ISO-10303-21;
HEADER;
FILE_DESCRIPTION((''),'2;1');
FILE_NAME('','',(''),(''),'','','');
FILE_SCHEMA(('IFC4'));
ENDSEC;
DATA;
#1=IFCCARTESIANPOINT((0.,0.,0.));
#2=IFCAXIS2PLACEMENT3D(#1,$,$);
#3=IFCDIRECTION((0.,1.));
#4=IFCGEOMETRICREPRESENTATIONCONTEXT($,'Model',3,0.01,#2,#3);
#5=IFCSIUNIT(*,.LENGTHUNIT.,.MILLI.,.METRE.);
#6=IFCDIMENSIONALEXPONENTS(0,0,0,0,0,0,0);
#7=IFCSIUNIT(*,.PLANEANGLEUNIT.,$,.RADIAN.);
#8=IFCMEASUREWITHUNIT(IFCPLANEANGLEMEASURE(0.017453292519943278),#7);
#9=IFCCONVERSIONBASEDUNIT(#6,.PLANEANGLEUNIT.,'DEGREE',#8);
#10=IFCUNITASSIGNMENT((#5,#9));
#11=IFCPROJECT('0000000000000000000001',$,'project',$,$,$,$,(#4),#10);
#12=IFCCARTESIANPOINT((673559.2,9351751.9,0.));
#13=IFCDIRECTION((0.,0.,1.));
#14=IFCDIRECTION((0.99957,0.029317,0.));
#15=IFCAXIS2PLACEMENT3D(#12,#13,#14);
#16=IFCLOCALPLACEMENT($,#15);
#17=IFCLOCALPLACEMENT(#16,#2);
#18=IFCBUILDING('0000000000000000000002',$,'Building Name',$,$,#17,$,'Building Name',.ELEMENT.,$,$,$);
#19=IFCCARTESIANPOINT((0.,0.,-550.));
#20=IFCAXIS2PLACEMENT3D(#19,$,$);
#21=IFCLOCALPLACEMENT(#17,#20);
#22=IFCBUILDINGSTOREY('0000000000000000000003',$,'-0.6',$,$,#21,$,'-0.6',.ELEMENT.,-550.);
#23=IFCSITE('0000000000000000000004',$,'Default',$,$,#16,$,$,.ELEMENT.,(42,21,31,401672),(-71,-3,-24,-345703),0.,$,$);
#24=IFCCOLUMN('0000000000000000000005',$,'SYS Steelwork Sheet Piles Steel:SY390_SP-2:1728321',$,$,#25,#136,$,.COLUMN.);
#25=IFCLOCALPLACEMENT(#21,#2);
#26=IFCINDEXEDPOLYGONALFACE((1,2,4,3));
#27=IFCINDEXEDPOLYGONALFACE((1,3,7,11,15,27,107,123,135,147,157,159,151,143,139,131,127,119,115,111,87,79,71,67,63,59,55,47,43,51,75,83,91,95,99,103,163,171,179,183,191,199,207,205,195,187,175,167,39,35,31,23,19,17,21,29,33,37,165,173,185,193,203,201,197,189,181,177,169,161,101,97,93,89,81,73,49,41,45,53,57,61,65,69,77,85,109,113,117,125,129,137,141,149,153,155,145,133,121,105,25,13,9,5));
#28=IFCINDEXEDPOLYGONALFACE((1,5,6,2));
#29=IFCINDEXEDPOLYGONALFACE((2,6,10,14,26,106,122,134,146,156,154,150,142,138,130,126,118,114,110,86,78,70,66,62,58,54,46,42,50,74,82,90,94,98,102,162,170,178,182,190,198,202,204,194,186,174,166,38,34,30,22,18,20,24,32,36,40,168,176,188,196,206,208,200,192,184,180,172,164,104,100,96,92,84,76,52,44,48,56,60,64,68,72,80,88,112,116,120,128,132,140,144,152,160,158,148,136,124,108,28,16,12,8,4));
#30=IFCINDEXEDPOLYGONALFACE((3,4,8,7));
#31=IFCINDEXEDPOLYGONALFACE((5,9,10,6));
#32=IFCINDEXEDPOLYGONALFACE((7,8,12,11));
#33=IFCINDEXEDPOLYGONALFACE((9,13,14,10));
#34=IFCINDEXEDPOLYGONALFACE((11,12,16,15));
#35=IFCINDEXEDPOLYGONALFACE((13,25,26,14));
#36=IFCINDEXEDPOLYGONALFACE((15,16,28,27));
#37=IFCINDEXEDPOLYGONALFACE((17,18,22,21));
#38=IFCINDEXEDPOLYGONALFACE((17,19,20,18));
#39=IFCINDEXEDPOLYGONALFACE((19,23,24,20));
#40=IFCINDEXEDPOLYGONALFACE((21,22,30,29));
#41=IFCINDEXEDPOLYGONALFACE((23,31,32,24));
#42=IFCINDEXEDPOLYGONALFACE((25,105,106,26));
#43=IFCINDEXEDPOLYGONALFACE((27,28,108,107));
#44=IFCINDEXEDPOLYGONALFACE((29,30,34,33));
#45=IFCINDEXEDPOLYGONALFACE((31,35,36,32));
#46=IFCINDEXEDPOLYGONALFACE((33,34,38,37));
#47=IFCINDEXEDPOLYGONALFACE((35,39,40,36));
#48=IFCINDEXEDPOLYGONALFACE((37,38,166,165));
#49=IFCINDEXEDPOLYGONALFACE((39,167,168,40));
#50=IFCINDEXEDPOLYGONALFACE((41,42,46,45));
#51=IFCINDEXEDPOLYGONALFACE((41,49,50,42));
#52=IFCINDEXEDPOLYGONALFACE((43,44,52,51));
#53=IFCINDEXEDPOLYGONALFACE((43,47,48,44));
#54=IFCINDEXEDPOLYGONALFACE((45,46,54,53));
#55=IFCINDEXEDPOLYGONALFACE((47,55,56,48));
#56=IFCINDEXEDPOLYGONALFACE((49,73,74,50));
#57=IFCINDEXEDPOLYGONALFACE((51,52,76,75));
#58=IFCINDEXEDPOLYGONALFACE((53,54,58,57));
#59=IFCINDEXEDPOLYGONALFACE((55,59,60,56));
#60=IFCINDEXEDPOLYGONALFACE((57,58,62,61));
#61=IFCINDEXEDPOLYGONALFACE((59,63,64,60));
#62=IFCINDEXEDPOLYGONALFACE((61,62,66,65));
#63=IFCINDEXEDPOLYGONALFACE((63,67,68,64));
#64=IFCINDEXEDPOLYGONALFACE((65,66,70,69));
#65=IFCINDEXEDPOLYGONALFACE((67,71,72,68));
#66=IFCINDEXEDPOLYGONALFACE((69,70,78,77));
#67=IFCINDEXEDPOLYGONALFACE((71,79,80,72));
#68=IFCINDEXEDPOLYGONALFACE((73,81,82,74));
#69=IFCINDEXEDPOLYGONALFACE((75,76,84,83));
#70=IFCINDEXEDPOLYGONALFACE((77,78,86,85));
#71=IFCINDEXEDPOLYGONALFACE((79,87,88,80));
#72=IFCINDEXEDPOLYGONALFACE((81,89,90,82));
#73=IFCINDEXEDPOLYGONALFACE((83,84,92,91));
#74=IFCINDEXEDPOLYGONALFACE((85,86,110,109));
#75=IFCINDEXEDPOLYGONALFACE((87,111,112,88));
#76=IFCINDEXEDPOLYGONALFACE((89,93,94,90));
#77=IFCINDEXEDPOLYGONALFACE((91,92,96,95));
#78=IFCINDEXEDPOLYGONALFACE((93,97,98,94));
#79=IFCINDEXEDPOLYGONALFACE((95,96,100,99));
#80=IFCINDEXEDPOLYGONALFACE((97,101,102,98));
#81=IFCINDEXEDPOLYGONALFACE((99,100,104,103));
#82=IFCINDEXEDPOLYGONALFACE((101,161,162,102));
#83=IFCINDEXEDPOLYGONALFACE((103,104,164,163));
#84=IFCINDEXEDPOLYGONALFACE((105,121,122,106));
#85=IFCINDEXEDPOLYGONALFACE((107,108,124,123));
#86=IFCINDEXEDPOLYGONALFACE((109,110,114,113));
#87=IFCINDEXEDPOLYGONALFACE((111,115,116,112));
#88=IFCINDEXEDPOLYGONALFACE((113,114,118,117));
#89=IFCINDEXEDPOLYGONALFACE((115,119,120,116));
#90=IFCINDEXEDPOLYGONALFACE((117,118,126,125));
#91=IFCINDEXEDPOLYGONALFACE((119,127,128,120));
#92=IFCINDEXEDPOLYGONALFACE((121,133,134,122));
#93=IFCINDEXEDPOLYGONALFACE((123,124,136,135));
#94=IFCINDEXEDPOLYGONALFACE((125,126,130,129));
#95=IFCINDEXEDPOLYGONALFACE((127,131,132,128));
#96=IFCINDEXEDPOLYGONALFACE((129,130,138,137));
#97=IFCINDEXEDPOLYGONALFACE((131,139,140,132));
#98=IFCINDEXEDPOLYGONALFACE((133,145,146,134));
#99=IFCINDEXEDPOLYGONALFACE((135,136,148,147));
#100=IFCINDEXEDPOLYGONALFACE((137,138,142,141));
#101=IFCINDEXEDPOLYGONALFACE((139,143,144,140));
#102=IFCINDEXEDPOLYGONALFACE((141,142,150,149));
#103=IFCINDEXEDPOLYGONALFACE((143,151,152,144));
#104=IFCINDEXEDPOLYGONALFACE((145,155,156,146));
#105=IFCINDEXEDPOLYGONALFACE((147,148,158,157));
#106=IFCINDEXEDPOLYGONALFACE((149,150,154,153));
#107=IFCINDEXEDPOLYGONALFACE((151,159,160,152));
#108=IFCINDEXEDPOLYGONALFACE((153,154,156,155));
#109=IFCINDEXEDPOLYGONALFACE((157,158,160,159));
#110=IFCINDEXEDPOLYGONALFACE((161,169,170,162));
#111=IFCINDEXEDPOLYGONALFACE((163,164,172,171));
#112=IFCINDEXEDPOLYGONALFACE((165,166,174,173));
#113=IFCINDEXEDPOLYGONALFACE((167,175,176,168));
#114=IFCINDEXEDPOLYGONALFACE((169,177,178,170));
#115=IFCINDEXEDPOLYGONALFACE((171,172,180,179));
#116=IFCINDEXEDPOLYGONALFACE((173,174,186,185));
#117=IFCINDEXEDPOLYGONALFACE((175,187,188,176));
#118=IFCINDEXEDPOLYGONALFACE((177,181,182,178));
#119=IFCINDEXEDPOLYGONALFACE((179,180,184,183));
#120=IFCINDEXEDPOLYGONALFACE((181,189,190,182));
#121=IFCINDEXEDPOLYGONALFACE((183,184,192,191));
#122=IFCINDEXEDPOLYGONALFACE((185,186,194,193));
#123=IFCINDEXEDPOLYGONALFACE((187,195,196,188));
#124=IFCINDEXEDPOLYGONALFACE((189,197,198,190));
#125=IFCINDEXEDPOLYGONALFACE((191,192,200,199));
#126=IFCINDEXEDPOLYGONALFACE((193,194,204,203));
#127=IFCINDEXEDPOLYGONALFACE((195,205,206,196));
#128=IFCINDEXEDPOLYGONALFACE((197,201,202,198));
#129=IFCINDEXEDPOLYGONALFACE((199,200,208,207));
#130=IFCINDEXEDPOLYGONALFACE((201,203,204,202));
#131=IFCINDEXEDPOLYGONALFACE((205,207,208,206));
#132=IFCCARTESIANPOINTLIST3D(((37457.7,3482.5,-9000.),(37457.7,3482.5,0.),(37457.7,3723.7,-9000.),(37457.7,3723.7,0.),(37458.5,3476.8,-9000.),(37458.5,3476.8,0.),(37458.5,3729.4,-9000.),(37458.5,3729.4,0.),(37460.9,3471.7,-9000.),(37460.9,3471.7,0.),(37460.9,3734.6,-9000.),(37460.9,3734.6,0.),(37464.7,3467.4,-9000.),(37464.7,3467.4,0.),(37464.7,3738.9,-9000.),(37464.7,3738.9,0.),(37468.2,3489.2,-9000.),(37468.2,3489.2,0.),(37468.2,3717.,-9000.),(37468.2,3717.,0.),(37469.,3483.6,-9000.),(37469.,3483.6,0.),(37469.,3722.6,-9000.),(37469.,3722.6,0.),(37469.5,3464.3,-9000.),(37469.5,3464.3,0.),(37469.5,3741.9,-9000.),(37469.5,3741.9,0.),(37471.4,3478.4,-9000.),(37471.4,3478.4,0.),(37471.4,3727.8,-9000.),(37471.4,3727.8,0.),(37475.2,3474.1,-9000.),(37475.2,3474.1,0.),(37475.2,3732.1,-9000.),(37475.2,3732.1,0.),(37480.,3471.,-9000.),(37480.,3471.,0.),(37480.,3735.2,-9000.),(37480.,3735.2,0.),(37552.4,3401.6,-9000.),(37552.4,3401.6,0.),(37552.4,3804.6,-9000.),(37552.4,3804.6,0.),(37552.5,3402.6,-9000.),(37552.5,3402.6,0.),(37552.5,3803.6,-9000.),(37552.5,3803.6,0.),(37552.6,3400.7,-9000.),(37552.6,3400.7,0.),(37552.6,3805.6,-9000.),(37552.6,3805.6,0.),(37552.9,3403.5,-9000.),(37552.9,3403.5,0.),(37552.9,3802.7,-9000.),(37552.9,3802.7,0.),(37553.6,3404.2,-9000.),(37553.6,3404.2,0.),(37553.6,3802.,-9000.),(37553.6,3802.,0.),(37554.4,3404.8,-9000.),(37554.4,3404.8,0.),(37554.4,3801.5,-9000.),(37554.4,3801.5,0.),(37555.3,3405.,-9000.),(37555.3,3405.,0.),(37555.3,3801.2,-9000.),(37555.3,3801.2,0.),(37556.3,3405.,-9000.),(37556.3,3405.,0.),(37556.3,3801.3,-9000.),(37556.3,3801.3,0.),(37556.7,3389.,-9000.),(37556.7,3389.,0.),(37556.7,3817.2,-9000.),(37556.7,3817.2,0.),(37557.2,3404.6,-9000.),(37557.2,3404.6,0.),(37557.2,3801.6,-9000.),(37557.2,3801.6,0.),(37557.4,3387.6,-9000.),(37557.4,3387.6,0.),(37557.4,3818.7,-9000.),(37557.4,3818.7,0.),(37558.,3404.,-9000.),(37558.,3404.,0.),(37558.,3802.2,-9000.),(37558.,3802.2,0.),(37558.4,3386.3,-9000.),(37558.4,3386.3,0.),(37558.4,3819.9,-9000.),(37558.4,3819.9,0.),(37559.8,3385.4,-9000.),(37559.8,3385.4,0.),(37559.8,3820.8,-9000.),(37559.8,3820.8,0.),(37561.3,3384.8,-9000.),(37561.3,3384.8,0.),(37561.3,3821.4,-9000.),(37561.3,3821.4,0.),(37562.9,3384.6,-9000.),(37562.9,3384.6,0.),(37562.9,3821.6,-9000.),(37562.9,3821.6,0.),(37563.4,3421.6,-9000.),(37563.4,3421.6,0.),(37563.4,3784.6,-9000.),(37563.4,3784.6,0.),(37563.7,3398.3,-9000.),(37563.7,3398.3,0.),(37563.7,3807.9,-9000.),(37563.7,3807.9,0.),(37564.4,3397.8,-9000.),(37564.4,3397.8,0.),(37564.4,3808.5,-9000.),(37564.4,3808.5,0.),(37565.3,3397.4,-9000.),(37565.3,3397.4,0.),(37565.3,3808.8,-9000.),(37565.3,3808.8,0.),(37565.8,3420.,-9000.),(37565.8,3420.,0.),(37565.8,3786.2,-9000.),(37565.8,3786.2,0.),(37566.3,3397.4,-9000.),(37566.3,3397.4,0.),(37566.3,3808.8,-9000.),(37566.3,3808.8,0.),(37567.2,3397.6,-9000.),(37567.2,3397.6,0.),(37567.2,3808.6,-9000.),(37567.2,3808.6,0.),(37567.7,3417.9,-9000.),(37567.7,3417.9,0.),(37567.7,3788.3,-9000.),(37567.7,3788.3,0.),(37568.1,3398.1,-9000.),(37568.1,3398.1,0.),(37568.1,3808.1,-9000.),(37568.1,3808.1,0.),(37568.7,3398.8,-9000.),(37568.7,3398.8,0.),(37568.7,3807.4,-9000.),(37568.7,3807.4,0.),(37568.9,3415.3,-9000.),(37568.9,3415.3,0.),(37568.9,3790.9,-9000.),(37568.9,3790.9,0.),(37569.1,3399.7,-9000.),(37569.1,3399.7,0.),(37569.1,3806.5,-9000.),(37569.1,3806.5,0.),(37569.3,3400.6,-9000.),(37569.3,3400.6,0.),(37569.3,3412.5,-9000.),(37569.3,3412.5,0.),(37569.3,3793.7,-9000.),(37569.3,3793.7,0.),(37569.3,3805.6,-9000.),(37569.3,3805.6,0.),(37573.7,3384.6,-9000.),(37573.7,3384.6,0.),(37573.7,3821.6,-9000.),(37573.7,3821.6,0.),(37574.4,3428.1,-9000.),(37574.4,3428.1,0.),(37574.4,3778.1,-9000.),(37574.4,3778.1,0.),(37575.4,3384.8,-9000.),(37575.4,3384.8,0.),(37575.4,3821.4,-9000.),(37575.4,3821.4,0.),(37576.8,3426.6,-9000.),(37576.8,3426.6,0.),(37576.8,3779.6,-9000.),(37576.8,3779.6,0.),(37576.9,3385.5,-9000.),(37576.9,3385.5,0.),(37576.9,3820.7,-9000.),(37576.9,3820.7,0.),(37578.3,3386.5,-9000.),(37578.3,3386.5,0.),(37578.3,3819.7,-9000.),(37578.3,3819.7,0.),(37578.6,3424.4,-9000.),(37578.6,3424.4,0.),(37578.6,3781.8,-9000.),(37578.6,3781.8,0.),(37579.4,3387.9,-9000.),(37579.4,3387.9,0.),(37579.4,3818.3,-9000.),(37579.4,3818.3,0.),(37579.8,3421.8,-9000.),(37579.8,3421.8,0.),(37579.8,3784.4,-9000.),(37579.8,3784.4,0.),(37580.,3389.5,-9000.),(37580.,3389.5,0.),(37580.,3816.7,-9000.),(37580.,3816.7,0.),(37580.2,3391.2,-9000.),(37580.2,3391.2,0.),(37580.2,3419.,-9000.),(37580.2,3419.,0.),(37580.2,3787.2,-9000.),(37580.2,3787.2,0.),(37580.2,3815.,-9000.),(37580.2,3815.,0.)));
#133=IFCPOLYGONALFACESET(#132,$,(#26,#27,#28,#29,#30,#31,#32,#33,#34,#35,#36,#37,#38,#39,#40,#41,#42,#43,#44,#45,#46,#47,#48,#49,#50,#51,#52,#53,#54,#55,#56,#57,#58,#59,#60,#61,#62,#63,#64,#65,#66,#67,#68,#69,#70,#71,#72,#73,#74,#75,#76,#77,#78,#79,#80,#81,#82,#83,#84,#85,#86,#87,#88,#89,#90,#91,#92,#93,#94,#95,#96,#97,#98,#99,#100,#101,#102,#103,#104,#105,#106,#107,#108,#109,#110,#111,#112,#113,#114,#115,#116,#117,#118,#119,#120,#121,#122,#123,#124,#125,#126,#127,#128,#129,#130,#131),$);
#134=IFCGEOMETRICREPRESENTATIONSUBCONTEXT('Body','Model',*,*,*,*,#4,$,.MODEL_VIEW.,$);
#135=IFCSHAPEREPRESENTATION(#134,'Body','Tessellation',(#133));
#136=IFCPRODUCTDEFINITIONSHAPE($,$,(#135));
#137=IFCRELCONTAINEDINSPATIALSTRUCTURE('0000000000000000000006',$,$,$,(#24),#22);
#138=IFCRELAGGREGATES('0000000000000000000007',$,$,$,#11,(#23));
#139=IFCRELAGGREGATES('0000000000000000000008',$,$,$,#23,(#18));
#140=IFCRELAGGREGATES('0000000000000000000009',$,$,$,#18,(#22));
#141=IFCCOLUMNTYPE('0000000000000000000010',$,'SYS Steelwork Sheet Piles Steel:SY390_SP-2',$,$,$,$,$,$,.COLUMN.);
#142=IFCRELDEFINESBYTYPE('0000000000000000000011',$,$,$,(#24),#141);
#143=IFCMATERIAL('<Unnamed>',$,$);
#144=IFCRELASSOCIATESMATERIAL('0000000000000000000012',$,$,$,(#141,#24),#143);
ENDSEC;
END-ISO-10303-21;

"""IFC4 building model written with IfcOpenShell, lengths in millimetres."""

from ifc_helpers import new_model, entity, si_unit, converted_unit, direction, frame, origin, place, context, subcontext, project, spatial, line, arc, indexed_curve, outline, extrude, source, transform, mapped, material, type_object, type_shapes, element, save


model = new_model("IFC4")

# Units and contexts
model_context = context("Model", 3, precision=0.01, world=origin(), true_north=direction((0.0, 1.0)))
body_context = subcontext(model_context, "Body", "Model", "MODEL_VIEW")
ifc_project = project(units=[si_unit("LENGTHUNIT", "METRE", prefix="MILLI"), converted_unit("PLANEANGLEUNIT", "DEGREE", entity("IfcPlaneAngleMeasure", 0.017453292519943278), si_unit("PLANEANGLEUNIT", "RADIAN"), dimensions=[0, 0, 0, 0, 0, 0, 0])], contexts=[model_context])

# Site, building, storey
site_placement = place(None, frame((673559.2, 9351751.9, 0.0), z_axis=(0.0, 0.0, 1.0), x_axis=(0.99957, 0.029317, 0.0)))
site = spatial("IfcSite", under=ifc_project, at=site_placement, Name="Default", CompositionType="ELEMENT", RefLatitude=(42, 21, 31, 401672), RefLongitude=(-71, -3, -24, -345703), RefElevation=0.0)
building_placement = place(site_placement, origin())
building = spatial("IfcBuilding", under=site, at=building_placement, Name="Building Name", LongName="Building Name", CompositionType="ELEMENT")
storey_placement = place(building_placement, frame((0.0, 0.0, -550.0)))
storey = spatial("IfcBuildingStorey", under=building, at=storey_placement, Name="-0.6", LongName="-0.6", CompositionType="ELEMENT", Elevation=-550.0)

# Column
ifc_material_1 = material(Name="<Unnamed>")
column_type = type_object("IfcColumnType", Name="SYS Steelwork Sheet Piles Steel:SY390_SP-2", PredefinedType="COLUMN", material=ifc_material_1)
shared_shape = source(origin(), body_context, "Body", "SweptSolid", [
    extrude(outline(indexed_curve([(-120.6, 84.7), (-131.4, 81.6), (-138.8, 73.0), (-181.5, -20.9), (-185.2, -25.2), (-190.6, -26.8), (-202.5, -26.8), (-205.5, -24.8), (-204.8, -21.2), (-199.1, -15.5), (-198.6, -11.5), (-202.5, -10.1), (-214.1, -14.2), (-217.3, -16.6), (-218.5, -20.4), (-218.5, -31.2), (-216.6, -35.8), (-211.9, -37.8), (-184.1, -37.8), (-178.7, -36.2), (-175.0, -31.9), (-132.1, 62.5), (-124.7, 71.1), (-113.9, 74.2), (113.9, 74.2), (124.7, 71.1), (132.1, 62.5), (175.0, -31.9), (178.7, -36.2), (184.1, -37.8), (211.9, -37.8), (216.6, -35.8), (218.5, -31.2), (218.5, -20.4), (217.3, -16.6), (214.1, -14.2), (202.5, -10.1), (198.6, -11.5), (199.1, -15.5), (204.8, -21.2), (205.5, -24.8), (202.5, -26.8), (190.6, -26.8), (185.2, -25.2), (181.5, -20.9), (138.8, 73.0), (131.4, 81.6), (120.6, 84.7)], segments=[arc(1, 2, 3), line(3, 4), arc(4, 5, 6), line(6, 7), arc(7, 8, 9), line(9, 10), arc(10, 11, 12), line(12, 13), arc(13, 14, 15), line(15, 16), arc(16, 17, 18), line(18, 19), arc(19, 20, 21), line(21, 22), arc(22, 23, 24), line(24, 25), arc(25, 26, 27), line(27, 28), arc(28, 29, 30), line(30, 31), arc(31, 32, 33), line(33, 34), arc(34, 35, 36), line(36, 37), arc(37, 38, 39), line(39, 40), arc(40, 41, 42), line(42, 43), arc(43, 44, 45), line(45, 46), arc(46, 47, 48), line(48, 1)], self_intersect=False)), frame((0.0, 15.3, -9550.0)), (0.0, 0.0, 1.0), 9000.0),
])
type_shapes(column_type, [shared_shape])
for number, where, z_axis, x_axis, name in (
    (1, (37557.7, 3603.1, 550.0), (0.0, 0.0, 1.0), (0.0, 1.0, 0.0), "SYS Steelwork Sheet Piles Steel:SY390_SP-2:1728321"),
):
    element("IfcColumn", number, at=place(storey_placement, frame(where, z_axis=z_axis, x_axis=x_axis)), inside=storey, type_object=column_type, material=ifc_material_1, Name=name, PredefinedType="COLUMN", context=body_context, shape_type="MappedRepresentation", body=[
        mapped(shared_shape, transform((0.0, 0.0, 0.0), scale=1.0)),
    ])

save(model, "model.ifc")
